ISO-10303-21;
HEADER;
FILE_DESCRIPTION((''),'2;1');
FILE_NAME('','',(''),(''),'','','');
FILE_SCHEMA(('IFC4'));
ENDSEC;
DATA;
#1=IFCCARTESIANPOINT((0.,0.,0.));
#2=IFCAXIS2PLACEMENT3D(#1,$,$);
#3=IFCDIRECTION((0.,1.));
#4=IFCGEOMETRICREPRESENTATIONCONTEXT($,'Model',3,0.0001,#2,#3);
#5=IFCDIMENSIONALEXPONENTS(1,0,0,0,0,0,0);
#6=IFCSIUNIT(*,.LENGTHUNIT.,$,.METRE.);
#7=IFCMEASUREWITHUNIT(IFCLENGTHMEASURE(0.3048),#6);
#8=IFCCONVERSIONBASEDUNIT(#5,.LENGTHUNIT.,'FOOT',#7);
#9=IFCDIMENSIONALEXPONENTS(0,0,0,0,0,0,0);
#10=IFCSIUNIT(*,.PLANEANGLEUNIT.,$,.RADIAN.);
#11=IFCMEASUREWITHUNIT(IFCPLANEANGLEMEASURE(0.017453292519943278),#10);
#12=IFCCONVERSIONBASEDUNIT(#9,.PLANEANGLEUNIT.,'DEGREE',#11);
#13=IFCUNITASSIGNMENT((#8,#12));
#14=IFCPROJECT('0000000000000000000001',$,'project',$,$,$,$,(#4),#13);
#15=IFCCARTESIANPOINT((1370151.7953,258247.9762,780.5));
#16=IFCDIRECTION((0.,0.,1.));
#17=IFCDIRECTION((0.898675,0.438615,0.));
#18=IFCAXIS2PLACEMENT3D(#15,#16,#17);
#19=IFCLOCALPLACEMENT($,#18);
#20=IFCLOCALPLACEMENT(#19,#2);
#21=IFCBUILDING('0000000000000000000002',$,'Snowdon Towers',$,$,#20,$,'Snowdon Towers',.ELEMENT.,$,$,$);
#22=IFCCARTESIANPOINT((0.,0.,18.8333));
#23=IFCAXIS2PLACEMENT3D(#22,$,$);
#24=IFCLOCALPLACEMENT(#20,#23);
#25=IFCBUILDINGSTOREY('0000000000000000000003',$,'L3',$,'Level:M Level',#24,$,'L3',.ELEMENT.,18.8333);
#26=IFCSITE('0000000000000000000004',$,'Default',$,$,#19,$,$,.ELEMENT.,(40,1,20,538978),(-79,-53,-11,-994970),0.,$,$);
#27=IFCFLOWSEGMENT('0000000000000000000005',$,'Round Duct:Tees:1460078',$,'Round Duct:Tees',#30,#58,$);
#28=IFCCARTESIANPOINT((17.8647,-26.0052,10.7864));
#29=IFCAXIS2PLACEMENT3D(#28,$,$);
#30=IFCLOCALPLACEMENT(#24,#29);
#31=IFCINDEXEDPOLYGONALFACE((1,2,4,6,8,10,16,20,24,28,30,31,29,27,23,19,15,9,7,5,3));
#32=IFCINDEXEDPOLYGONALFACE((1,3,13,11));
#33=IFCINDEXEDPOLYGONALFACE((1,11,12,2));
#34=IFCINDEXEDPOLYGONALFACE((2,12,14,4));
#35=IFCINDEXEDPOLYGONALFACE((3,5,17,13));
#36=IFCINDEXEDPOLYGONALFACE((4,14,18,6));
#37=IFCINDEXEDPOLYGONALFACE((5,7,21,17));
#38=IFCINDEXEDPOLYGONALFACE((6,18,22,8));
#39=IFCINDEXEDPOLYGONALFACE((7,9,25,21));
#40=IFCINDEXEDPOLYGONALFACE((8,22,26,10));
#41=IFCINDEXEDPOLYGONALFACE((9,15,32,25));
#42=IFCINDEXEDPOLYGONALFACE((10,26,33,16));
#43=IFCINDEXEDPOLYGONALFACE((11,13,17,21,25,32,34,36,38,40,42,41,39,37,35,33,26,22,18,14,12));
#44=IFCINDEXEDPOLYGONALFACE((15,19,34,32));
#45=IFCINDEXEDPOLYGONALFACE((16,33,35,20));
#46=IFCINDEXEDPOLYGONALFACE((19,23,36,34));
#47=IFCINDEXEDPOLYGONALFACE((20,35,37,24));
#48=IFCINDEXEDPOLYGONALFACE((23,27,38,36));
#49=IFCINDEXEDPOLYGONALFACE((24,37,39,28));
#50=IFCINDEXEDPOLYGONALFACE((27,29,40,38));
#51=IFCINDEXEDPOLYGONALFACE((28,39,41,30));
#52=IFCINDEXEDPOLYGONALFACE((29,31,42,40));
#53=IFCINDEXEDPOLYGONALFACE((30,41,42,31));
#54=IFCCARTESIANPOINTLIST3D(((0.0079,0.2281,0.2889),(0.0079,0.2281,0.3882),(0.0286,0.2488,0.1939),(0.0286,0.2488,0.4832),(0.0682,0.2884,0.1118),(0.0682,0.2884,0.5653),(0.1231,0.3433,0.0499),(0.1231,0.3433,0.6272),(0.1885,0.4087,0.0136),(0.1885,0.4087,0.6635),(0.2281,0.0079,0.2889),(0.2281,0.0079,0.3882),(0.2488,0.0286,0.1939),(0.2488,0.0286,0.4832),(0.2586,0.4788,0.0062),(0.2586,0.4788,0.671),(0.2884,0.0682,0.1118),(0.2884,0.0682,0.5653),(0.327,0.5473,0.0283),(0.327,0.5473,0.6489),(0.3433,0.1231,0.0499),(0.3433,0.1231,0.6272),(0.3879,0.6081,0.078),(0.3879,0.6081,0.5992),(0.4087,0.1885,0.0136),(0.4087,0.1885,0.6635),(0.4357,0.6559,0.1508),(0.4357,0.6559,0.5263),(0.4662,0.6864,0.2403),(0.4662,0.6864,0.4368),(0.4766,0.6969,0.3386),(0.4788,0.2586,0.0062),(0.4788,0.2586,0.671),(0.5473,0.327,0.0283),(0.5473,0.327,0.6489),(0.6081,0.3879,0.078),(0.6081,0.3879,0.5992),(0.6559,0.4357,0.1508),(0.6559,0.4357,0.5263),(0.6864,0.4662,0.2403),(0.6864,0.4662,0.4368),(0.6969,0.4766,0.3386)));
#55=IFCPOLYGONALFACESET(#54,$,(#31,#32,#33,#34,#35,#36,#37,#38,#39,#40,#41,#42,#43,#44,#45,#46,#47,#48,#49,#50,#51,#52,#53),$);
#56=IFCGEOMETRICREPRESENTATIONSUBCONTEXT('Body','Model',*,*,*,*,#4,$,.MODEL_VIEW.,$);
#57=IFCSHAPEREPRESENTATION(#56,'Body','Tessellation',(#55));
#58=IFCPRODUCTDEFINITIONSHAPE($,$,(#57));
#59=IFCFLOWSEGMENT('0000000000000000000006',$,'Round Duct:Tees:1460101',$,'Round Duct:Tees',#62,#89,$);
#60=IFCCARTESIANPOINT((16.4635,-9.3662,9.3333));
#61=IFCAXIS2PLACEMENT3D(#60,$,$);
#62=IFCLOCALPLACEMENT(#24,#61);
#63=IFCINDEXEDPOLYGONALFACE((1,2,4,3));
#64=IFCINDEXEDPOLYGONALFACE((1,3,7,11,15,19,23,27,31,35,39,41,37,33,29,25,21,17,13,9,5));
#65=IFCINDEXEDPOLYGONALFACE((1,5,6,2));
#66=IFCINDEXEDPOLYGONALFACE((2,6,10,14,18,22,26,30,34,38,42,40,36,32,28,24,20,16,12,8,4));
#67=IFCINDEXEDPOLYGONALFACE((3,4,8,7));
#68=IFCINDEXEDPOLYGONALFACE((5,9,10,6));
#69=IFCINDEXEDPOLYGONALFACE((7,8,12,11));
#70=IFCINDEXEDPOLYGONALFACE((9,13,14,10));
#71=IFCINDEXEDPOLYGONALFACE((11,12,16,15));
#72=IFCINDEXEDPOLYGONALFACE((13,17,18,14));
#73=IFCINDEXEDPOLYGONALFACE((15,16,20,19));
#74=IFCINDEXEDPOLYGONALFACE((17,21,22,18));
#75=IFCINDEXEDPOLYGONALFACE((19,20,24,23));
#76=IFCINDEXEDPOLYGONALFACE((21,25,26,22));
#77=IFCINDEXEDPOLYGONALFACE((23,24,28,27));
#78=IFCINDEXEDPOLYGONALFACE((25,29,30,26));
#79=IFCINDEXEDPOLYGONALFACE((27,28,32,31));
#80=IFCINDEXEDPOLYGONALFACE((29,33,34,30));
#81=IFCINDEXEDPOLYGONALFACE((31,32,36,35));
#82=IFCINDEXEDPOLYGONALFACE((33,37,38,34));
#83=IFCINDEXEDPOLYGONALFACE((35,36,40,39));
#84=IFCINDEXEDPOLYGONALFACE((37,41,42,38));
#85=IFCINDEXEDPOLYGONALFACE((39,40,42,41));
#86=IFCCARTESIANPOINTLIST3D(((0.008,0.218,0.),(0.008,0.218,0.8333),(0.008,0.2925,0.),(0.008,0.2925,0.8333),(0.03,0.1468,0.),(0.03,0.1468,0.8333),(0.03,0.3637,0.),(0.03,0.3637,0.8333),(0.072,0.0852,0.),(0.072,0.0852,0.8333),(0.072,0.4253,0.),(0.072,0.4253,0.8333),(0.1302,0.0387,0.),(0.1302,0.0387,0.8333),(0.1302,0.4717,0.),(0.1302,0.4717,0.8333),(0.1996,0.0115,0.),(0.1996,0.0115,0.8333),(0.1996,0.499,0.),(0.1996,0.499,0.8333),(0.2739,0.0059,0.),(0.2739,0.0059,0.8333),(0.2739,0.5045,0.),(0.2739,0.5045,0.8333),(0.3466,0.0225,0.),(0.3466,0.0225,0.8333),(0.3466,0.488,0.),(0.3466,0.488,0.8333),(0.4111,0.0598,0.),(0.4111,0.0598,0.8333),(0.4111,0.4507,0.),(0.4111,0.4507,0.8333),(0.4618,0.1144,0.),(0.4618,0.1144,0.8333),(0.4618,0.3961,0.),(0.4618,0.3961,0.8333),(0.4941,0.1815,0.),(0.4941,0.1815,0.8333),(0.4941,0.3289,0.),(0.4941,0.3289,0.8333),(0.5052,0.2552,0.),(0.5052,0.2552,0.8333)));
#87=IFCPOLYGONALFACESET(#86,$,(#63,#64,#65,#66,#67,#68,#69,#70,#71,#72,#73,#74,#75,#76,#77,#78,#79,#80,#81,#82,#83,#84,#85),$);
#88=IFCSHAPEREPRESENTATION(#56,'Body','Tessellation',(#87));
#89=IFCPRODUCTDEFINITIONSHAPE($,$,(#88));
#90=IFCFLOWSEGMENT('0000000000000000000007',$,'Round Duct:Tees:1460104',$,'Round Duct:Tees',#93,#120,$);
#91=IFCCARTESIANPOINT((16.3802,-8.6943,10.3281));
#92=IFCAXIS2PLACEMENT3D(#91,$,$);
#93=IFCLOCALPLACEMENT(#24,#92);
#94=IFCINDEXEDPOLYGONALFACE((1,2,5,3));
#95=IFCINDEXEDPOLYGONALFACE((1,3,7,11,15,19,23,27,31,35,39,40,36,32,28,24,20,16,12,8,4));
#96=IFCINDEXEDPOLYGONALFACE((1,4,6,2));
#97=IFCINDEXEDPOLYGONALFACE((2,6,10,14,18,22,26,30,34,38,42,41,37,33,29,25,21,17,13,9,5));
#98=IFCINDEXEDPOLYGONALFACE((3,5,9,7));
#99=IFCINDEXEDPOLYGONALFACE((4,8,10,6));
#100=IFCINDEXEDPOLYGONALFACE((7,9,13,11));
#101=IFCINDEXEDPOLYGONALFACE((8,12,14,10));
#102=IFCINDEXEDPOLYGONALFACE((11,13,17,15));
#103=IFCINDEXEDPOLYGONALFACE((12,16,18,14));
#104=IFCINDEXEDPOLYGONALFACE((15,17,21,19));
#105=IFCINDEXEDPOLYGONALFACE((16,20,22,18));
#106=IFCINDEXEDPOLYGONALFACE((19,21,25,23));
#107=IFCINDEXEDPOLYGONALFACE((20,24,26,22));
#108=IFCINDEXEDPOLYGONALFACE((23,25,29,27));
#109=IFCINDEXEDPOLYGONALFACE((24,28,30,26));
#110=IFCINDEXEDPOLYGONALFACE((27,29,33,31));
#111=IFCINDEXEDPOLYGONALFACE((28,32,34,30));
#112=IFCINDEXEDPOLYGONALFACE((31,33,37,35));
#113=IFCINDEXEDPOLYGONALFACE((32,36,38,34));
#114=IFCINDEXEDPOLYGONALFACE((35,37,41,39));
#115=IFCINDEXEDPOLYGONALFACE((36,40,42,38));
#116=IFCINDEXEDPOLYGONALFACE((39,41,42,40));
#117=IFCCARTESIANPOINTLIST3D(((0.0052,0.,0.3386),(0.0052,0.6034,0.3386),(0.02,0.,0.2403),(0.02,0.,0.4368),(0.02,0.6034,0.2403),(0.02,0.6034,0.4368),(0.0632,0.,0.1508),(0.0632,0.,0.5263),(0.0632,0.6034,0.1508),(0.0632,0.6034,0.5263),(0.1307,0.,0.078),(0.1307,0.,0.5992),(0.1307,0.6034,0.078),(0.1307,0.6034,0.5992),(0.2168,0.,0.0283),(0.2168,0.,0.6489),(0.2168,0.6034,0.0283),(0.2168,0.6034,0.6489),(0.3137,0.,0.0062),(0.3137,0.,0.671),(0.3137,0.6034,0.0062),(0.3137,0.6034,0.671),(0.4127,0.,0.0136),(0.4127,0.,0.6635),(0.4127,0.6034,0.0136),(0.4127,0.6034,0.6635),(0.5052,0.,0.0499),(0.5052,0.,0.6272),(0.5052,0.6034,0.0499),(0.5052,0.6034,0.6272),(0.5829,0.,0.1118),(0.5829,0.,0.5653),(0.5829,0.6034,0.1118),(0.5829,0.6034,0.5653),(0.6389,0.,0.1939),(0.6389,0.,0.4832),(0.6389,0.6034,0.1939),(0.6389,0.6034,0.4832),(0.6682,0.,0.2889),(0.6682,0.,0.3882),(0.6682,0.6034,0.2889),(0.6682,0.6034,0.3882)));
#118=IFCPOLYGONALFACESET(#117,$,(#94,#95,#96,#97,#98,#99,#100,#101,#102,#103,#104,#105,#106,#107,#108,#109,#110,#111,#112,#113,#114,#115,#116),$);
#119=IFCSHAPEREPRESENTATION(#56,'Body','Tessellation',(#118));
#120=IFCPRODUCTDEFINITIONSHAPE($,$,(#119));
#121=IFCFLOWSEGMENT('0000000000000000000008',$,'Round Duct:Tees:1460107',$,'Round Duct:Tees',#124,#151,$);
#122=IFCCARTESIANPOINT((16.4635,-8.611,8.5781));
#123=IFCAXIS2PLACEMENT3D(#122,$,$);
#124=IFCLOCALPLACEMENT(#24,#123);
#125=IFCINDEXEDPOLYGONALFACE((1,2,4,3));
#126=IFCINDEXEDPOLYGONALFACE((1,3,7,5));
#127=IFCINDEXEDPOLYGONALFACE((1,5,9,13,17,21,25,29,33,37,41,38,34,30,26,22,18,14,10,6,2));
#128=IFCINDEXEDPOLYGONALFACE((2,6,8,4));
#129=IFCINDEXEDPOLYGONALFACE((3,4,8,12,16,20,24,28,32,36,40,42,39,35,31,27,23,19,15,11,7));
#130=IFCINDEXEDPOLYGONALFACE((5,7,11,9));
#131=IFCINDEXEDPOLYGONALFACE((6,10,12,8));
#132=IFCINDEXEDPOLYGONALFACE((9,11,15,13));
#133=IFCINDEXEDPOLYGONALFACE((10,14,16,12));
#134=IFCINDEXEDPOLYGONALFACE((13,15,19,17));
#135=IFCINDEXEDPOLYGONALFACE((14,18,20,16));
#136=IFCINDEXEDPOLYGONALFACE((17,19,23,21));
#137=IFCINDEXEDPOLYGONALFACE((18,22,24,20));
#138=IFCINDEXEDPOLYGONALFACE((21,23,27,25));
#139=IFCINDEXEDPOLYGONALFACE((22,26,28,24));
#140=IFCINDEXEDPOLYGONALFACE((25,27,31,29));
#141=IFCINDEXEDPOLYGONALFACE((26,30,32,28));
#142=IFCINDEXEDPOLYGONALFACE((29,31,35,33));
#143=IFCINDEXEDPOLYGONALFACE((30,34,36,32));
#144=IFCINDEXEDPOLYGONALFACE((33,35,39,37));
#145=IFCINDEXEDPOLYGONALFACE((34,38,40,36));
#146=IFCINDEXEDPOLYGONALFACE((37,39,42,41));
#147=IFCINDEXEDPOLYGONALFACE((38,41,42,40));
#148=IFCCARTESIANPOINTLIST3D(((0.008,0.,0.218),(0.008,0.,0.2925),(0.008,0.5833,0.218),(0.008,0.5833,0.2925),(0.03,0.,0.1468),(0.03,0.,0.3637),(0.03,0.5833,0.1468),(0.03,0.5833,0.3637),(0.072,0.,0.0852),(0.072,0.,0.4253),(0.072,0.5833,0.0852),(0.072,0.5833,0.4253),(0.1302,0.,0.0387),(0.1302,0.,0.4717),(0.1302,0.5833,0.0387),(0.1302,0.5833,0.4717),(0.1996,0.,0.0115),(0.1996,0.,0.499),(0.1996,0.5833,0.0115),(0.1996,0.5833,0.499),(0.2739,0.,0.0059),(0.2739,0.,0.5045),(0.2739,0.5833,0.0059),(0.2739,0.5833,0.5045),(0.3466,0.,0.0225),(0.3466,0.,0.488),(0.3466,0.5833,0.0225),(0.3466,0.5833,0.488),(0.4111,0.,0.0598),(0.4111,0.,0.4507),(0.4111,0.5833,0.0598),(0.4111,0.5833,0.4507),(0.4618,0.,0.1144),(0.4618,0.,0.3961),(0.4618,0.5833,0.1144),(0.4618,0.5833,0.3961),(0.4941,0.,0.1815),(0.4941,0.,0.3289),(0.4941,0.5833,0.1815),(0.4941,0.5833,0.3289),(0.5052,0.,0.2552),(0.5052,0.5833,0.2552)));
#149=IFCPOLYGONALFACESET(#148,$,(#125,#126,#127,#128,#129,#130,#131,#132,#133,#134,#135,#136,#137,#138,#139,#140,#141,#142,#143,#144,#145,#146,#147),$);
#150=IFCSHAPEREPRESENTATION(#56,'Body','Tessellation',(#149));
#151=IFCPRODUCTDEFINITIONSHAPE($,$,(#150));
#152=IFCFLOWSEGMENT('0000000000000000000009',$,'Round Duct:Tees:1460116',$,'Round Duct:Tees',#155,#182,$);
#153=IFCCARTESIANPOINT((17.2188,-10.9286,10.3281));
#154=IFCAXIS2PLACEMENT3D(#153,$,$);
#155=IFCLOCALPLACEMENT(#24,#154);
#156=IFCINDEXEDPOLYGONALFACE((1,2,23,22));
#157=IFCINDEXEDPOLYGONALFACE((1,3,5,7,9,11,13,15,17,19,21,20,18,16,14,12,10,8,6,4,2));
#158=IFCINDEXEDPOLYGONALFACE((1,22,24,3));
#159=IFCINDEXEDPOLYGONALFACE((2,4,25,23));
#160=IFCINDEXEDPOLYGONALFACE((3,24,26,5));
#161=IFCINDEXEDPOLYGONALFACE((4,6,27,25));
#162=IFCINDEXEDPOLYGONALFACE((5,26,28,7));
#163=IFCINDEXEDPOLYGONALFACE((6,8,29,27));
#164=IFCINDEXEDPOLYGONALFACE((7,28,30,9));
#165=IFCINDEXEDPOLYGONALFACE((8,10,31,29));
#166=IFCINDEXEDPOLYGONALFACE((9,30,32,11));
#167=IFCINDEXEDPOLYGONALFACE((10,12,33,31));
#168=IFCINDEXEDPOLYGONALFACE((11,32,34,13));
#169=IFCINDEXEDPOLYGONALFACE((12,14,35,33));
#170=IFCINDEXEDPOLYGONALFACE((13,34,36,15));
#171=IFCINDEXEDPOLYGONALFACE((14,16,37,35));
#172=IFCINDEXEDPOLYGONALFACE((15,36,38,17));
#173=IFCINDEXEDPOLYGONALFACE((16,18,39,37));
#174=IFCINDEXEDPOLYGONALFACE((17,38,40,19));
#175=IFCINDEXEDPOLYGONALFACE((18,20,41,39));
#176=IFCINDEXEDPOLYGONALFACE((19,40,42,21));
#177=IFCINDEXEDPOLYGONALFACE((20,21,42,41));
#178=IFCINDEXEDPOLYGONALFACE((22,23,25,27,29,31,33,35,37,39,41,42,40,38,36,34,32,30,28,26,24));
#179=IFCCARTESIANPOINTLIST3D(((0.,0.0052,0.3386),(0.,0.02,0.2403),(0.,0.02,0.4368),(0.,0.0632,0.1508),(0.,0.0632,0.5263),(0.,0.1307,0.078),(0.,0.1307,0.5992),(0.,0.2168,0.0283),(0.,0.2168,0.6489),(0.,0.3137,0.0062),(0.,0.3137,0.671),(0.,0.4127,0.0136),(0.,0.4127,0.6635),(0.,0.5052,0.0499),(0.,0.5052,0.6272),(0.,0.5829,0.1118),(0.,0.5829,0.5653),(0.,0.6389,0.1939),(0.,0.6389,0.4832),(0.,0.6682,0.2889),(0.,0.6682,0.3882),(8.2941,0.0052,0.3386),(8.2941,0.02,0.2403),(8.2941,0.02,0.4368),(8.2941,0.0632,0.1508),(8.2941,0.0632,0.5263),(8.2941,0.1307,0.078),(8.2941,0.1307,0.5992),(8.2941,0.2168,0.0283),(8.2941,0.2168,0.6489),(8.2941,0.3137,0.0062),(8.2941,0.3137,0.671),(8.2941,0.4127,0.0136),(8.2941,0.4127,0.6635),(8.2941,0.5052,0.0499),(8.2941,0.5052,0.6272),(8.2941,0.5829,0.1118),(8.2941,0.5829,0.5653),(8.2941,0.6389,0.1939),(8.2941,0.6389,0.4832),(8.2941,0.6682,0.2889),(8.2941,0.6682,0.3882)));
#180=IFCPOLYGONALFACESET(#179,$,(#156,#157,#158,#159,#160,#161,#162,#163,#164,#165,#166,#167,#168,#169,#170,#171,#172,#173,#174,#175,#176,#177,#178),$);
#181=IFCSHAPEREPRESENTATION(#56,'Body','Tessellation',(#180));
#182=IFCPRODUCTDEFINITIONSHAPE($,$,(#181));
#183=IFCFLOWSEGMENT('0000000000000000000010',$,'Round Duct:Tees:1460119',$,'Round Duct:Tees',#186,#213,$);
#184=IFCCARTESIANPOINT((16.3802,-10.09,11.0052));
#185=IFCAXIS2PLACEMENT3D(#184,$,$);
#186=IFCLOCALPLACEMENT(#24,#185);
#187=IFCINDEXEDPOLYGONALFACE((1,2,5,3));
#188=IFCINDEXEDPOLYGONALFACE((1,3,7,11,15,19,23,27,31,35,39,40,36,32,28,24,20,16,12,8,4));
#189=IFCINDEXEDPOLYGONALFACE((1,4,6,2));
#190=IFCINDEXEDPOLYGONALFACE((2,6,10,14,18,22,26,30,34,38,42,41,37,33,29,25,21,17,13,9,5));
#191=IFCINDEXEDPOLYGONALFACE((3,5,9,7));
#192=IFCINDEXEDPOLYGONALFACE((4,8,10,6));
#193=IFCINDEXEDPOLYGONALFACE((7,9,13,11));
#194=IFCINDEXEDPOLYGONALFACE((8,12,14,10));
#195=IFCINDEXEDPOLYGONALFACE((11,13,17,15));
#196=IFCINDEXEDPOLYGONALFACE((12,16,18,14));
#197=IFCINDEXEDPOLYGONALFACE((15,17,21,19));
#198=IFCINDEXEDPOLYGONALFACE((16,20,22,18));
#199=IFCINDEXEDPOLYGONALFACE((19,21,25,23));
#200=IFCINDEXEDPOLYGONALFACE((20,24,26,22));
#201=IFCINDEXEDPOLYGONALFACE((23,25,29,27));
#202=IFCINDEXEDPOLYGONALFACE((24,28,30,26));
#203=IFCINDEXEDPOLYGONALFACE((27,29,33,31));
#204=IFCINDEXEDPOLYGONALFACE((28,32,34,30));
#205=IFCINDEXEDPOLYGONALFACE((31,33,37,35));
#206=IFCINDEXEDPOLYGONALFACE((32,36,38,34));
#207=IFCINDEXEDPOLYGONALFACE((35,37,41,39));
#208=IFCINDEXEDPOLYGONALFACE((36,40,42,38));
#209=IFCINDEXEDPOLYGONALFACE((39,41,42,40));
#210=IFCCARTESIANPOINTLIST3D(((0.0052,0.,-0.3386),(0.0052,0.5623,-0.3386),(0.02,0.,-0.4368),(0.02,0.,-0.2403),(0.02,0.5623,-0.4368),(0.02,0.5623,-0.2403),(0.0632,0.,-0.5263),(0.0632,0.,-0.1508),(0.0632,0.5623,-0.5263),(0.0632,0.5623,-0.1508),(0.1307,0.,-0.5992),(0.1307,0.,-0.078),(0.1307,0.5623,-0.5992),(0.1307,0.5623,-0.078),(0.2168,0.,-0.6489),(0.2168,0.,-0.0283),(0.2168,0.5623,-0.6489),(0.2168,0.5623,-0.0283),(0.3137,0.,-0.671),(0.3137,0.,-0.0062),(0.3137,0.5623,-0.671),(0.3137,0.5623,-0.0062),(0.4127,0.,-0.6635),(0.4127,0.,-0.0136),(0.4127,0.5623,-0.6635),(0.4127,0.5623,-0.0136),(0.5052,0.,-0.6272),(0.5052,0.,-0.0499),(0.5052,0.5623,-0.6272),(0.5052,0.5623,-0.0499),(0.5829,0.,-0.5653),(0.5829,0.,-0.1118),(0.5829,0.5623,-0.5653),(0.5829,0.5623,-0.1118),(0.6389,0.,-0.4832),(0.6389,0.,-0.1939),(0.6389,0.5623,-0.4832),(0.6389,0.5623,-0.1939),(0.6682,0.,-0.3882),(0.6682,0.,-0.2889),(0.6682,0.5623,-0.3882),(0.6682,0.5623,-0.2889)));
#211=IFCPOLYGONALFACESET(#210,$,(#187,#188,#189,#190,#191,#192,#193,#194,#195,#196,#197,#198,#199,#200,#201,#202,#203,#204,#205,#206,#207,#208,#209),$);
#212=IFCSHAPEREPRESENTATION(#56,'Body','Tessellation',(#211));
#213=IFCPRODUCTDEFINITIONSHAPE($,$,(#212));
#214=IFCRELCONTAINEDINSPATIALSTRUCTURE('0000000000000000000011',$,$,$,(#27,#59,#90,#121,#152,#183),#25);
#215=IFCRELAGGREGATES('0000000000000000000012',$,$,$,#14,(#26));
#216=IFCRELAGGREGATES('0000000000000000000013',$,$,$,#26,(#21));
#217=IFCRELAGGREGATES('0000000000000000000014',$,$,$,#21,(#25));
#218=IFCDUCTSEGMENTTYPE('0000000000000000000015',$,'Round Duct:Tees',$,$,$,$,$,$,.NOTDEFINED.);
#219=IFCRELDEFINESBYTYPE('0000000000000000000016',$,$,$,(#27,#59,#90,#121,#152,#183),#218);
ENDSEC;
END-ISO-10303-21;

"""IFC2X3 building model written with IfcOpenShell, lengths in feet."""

from ifc_helpers import new_model, entity, si_unit, converted_unit, direction, frame, frame_2d, origin, origin_2d_with_axis, place, context, subcontext, project, spatial, circle, extrude, type_object, element, save


model = new_model("IFC2X3")

# Units and contexts
model_context = context("Model", 3, precision=0.0001, world=origin(), true_north=direction((0.0, 1.0)))
body_context = subcontext(model_context, "Body", "Model", "MODEL_VIEW")
ifc_project = project(units=[converted_unit("LENGTHUNIT", "FOOT", entity("IfcLengthMeasure", 0.3048), si_unit("LENGTHUNIT", "METRE"), dimensions=[1, 0, 0, 0, 0, 0, 0]), converted_unit("PLANEANGLEUNIT", "DEGREE", entity("IfcPlaneAngleMeasure", 0.017453292519943278), si_unit("PLANEANGLEUNIT", "RADIAN"), dimensions=[0, 0, 0, 0, 0, 0, 0])], contexts=[model_context])

# Site, building, storey
site_placement = place(None, frame((1370151.7953, 258247.9762, 780.5), z_axis=(0.0, 0.0, 1.0), x_axis=(0.898675, 0.438615, 0.0)))
site = spatial("IfcSite", under=ifc_project, at=site_placement, Name="Default", CompositionType="ELEMENT", RefLatitude=(40, 1, 20, 538978), RefLongitude=(-79, -53, -11, -994970), RefElevation=0.0)
building_placement = place(site_placement, origin())
building = spatial("IfcBuilding", under=site, at=building_placement, Name="Snowdon Towers", LongName="Snowdon Towers", CompositionType="ELEMENT")
storey_placement = place(building_placement, frame((0.0, 0.0, 18.8333)))
storey = spatial("IfcBuildingStorey", under=building, at=storey_placement, Name="L3", ObjectType="Level:M Level", LongName="L3", CompositionType="ELEMENT", Elevation=18.8333)

# Flow segments
duct_segment_type = type_object("IfcDuctSegmentType", Name="Round Duct:Tees", PredefinedType="NOTDEFINED")
flow_segment_1_placement = place(storey_placement, frame((17.8647, -26.0052, 10.7864)))
element("IfcFlowSegment", 1, at=flow_segment_1_placement, inside=storey, type_object=duct_segment_type, Name="Round Duct:Tees:1460078", ObjectType="Round Duct:Tees", context=body_context, shape_type="SweptSolid", body=[
    extrude(circle(Radius=0.3333, at=origin_2d_with_axis()), frame((0.4611, 0.2409, 0.3386), z_axis=(-0.707107, 0.707107, 0.0), x_axis=(0.707107, 0.707107, 0.0)), (0.0, 0.0, 1.0), 0.3114),
])
flow_segment_2_placement = place(storey_placement, frame((16.4635, -9.3662, 9.3333)))
element("IfcFlowSegment", 2, at=flow_segment_2_placement, inside=storey, type_object=duct_segment_type, Name="Round Duct:Tees:1460101", ObjectType="Round Duct:Tees", context=body_context, shape_type="SweptSolid", body=[
    extrude(circle(Radius=0.25, at=frame_2d((0.0, 0.0), x_axis=(1.0, 0.0))), frame((0.2552, 0.2552, 0.0)), (0.0, 0.0, 1.0), 0.8333),
])
flow_segment_3_placement = place(storey_placement, frame((16.3802, -8.6943, 10.3281)))
element("IfcFlowSegment", 3, at=flow_segment_3_placement, inside=storey, type_object=duct_segment_type, Name="Round Duct:Tees:1460104", ObjectType="Round Duct:Tees", context=body_context, shape_type="SweptSolid", body=[
    extrude(circle(Radius=0.3333, at=frame_2d((0.0, 0.0), x_axis=(1.0, 0.0))), frame((0.3386, 0.0, 0.3386), z_axis=(0.0, 1.0, 0.0), x_axis=(-1.0, 0.0, 0.0)), (0.0, 0.0, 1.0), 0.6034),
])
flow_segment_4_placement = place(storey_placement, frame((16.4635, -8.611, 8.5781)))
element("IfcFlowSegment", 4, at=flow_segment_4_placement, inside=storey, type_object=duct_segment_type, Name="Round Duct:Tees:1460107", ObjectType="Round Duct:Tees", context=body_context, shape_type="SweptSolid", body=[
    extrude(circle(Radius=0.25, at=origin_2d_with_axis()), frame((0.2552, 0.0, 0.2552), z_axis=(0.0, 1.0, 0.0), x_axis=(1.0, 0.0, 0.0)), (0.0, 0.0, 1.0), 0.5833),
])
flow_segment_5_placement = place(storey_placement, frame((17.2188, -10.9286, 10.3281)))
element("IfcFlowSegment", 5, at=flow_segment_5_placement, inside=storey, type_object=duct_segment_type, Name="Round Duct:Tees:1460116", ObjectType="Round Duct:Tees", context=body_context, shape_type="SweptSolid", body=[
    extrude(circle(Radius=0.3333, at=frame_2d((0.0, 0.0), x_axis=(1.0, 0.0))), frame((0.0, 0.3386, 0.3386), z_axis=(1.0, 0.0, 0.0), x_axis=(0.0, -1.0, 0.0)), (0.0, 0.0, 1.0), 8.2941),
])
flow_segment_6_placement = place(storey_placement, frame((16.3802, -10.09, 11.0052)))
element("IfcFlowSegment", 6, at=flow_segment_6_placement, inside=storey, type_object=duct_segment_type, Name="Round Duct:Tees:1460119", ObjectType="Round Duct:Tees", context=body_context, shape_type="SweptSolid", body=[
    extrude(circle(Radius=0.3333, at=frame_2d((0.0, 0.0), x_axis=(1.0, 0.0))), frame((0.3386, 0.0, -0.3386), z_axis=(0.0, 1.0, 0.0), x_axis=(-1.0, 0.0, 0.0)), (0.0, 0.0, 1.0), 0.5623),
])

save(model, "model.ifc")
